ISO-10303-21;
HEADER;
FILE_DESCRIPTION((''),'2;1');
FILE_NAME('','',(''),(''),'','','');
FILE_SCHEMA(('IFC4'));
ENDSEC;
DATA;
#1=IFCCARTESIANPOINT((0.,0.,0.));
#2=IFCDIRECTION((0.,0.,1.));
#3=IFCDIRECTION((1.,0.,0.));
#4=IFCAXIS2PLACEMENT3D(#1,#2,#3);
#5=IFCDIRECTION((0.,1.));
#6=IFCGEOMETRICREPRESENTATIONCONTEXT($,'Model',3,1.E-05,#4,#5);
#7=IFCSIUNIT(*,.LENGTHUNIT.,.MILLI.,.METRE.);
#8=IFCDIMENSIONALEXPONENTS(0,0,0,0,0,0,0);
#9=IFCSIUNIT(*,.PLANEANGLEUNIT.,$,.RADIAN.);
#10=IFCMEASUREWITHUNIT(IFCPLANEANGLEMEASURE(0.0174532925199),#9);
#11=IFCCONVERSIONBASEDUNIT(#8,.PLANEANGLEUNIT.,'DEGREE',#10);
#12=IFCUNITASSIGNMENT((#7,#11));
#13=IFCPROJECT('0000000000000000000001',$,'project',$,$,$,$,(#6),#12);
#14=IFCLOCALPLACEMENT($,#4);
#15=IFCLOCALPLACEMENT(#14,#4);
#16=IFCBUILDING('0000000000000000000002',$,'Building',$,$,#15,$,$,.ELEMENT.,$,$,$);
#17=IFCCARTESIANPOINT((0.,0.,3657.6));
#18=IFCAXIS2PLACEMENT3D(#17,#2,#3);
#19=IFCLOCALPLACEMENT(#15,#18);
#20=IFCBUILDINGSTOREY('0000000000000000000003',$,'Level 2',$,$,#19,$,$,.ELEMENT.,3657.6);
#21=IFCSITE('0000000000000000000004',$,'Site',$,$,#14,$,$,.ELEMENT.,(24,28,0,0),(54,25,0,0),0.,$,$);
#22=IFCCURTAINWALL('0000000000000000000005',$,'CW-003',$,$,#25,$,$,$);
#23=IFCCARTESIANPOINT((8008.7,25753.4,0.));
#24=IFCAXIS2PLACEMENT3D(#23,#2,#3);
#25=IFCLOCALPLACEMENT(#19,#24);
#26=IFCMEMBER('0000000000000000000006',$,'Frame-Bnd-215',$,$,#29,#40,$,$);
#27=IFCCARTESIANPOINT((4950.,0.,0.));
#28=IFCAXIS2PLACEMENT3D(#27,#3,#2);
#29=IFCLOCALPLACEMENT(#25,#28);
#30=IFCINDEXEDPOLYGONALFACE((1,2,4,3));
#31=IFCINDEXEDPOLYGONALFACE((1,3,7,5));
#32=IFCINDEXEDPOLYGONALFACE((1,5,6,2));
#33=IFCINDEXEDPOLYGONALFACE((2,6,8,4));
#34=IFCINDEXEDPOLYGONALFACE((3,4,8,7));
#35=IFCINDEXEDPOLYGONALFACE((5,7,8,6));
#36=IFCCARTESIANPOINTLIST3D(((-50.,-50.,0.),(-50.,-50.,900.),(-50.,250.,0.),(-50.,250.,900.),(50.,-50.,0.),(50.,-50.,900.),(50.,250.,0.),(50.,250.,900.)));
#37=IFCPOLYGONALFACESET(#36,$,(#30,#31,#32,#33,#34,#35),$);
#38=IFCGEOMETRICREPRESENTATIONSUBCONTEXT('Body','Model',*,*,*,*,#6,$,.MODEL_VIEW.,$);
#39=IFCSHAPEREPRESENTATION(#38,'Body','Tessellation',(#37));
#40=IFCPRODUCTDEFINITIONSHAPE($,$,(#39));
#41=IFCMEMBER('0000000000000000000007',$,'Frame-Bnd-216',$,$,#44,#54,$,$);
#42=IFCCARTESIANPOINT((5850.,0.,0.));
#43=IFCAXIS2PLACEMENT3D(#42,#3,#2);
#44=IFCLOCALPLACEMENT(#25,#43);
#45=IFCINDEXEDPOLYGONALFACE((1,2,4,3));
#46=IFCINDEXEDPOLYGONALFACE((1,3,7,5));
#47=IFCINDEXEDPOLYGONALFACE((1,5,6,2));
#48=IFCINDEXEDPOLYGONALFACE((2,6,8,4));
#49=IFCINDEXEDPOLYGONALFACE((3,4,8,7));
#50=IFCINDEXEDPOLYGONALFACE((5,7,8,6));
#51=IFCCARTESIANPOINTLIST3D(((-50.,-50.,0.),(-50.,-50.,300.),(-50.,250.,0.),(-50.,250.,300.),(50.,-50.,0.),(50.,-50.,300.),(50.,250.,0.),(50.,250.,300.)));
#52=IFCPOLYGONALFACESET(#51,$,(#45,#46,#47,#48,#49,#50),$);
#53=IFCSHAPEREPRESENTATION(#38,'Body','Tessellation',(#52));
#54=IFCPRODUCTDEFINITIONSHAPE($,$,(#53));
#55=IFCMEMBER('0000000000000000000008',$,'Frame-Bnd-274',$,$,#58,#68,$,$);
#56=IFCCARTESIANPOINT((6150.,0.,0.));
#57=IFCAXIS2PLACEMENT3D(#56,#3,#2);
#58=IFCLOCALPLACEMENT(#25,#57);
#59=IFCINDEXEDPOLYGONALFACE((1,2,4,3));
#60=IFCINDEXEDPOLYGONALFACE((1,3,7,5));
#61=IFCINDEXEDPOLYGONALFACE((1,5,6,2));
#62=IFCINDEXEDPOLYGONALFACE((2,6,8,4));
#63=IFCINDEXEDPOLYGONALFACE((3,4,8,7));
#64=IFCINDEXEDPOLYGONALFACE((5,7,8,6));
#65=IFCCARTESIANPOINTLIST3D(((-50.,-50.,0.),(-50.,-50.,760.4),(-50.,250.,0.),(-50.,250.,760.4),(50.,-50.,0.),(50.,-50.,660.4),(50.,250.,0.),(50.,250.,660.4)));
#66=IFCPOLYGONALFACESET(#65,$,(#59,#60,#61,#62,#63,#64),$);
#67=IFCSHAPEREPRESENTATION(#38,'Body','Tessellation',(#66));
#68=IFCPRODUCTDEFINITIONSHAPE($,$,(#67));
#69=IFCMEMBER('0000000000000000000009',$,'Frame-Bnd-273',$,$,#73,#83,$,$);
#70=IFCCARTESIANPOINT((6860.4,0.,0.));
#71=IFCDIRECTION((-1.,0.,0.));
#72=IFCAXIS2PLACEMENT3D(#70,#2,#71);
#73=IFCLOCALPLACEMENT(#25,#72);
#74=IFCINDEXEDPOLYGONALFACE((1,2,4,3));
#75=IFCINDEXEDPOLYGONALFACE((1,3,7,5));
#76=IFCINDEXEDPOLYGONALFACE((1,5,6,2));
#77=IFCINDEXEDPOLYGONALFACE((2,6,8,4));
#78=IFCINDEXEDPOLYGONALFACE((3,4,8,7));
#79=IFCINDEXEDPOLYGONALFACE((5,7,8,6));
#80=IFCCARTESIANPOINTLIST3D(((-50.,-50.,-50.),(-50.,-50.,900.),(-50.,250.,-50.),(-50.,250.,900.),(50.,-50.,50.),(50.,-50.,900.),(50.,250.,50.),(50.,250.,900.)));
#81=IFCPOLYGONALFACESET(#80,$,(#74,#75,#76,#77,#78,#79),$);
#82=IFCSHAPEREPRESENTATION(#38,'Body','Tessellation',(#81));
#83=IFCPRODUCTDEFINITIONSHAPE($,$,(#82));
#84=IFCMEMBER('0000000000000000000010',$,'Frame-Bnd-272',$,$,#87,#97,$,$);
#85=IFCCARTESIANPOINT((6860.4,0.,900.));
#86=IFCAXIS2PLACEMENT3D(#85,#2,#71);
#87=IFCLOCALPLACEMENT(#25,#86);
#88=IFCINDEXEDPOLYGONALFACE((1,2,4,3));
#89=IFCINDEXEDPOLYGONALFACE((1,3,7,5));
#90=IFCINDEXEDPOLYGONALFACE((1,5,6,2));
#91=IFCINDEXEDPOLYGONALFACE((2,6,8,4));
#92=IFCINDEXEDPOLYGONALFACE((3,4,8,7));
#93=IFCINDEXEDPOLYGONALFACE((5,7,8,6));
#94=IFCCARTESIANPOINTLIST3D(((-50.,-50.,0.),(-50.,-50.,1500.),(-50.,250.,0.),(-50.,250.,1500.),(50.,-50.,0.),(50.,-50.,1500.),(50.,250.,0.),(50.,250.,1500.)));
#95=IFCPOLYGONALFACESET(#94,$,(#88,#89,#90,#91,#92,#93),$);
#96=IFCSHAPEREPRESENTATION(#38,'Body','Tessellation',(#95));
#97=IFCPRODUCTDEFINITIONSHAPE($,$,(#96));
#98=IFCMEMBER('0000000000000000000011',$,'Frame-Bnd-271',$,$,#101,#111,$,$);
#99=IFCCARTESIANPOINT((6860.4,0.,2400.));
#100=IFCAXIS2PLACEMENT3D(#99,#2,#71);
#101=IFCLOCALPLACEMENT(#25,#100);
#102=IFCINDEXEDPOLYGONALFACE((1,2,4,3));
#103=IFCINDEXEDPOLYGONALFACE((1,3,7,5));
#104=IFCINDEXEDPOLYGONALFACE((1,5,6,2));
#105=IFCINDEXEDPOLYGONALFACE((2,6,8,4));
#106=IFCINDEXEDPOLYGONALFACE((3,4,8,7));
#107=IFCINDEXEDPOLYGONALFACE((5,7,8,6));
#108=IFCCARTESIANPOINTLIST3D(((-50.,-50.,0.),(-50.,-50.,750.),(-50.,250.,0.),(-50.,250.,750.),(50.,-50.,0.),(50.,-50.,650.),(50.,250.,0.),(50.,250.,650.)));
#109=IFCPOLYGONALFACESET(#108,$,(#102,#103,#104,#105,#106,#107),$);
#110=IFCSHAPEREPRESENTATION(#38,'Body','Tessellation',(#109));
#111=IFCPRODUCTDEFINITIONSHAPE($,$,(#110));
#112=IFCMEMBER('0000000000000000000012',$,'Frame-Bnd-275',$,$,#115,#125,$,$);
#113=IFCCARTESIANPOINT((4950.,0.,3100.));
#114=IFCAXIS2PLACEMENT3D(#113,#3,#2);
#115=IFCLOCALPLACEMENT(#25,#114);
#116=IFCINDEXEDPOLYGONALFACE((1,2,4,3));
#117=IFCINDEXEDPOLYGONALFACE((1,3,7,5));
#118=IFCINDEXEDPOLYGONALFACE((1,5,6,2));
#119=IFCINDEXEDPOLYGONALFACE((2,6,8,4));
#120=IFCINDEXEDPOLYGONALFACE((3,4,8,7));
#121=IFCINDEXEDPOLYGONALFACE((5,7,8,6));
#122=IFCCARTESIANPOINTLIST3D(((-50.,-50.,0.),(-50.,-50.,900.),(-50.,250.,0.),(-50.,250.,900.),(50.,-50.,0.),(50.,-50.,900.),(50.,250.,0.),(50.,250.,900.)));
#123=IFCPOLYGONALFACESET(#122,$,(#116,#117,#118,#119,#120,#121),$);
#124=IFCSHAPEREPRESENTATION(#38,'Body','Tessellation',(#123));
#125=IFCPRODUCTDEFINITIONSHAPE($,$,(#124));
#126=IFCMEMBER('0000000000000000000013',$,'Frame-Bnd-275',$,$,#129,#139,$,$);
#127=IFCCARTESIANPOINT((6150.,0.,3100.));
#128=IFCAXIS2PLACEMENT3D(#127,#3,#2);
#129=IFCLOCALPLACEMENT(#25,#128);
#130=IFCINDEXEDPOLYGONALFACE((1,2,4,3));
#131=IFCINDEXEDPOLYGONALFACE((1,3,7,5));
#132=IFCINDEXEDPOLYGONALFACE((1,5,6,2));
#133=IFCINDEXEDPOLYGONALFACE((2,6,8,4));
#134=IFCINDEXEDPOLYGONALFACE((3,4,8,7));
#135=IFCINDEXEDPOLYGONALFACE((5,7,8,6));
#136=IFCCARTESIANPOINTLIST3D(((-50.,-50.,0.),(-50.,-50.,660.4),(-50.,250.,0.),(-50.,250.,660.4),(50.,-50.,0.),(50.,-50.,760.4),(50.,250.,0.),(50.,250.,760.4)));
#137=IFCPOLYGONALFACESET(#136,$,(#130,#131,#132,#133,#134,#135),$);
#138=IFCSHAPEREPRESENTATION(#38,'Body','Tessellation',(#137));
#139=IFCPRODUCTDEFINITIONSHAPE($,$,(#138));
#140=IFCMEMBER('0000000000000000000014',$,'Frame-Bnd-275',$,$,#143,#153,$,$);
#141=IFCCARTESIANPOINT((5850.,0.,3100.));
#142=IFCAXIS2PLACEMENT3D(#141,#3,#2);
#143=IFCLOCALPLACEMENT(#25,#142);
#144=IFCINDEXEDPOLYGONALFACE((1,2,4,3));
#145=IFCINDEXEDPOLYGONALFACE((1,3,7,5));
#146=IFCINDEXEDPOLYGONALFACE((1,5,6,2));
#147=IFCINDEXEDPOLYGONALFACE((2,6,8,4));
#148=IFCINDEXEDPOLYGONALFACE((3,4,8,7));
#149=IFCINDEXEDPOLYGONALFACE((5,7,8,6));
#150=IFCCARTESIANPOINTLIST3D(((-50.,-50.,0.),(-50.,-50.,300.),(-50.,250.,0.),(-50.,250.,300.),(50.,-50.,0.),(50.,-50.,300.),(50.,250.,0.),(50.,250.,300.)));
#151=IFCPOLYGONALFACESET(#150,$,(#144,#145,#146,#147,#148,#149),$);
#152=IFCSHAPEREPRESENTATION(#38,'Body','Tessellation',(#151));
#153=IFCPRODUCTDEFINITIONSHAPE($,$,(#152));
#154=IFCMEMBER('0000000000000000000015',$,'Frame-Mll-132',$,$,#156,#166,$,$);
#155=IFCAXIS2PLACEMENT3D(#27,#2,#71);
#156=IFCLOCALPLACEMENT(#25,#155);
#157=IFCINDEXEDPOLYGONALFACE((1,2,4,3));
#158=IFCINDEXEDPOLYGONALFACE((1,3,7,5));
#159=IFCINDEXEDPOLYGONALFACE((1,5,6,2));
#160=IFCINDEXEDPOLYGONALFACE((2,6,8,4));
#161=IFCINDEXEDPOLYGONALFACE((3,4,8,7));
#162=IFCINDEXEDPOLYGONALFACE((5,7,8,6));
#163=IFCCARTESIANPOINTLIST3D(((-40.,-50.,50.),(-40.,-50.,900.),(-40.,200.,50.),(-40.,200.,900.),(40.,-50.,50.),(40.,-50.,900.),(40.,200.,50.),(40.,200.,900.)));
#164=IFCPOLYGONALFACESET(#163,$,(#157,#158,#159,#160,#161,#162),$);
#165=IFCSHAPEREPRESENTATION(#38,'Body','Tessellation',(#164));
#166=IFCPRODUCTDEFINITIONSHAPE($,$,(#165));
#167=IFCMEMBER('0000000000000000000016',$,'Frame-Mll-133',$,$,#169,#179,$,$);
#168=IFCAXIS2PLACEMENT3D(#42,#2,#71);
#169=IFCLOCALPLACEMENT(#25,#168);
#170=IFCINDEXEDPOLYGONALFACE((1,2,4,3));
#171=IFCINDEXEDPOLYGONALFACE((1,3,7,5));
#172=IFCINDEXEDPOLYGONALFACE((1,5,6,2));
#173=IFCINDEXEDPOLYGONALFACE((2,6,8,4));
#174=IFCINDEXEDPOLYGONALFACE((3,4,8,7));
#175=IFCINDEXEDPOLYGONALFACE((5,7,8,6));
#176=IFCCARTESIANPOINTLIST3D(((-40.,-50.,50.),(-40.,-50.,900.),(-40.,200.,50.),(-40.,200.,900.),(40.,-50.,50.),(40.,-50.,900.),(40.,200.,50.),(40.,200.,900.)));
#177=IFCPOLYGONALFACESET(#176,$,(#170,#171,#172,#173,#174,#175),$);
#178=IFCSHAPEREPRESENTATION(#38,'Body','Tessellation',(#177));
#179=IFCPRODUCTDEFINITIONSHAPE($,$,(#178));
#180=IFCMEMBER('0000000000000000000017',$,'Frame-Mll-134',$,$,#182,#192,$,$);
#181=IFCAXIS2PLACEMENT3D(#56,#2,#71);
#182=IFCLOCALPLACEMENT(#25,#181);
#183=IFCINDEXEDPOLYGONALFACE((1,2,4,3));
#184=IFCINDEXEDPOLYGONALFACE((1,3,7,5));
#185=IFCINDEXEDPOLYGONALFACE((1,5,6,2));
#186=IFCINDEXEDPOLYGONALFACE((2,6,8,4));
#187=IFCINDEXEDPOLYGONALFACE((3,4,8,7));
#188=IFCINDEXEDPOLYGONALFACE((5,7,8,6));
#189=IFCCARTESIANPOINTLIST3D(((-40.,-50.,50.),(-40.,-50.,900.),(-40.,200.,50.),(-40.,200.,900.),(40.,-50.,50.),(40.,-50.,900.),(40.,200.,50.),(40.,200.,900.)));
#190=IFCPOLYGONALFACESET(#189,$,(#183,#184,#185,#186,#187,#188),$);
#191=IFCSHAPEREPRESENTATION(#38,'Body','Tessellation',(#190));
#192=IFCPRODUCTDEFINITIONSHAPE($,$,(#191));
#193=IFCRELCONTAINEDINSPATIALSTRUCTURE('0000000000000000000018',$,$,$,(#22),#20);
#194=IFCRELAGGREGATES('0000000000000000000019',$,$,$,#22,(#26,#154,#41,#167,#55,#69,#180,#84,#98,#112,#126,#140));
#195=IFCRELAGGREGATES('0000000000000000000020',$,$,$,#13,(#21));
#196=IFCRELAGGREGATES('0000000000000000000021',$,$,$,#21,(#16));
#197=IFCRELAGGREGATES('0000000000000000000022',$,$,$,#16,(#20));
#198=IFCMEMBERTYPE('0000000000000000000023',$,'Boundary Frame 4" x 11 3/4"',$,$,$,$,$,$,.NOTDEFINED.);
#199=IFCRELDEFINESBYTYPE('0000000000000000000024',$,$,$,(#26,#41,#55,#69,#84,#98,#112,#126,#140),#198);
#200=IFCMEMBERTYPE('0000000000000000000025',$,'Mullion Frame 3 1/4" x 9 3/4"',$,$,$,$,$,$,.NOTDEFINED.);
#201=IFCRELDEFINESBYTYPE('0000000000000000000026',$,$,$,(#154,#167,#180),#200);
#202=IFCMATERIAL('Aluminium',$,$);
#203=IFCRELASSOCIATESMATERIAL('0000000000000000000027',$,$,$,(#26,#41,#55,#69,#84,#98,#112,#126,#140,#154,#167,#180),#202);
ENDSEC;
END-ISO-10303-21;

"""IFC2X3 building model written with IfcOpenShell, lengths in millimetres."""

from ifc_helpers import new_model, entity, si_unit, converted_unit, direction, frame, origin_with_axes, place, context, subcontext, project, spatial, polyline, outline, extrude, clip, halfspace, material, type_object, element, aggregate, save


model = new_model("IFC2X3")

# Units and contexts
model_context = context("Model", 3, precision=1e-05, world=origin_with_axes(), true_north=direction((0.0, 1.0)))
body_context = subcontext(model_context, "Body", "Model", "MODEL_VIEW")
ifc_project = project(units=[si_unit("LENGTHUNIT", "METRE", prefix="MILLI"), converted_unit("PLANEANGLEUNIT", "DEGREE", entity("IfcPlaneAngleMeasure", 0.0174532925199), si_unit("PLANEANGLEUNIT", "RADIAN"), dimensions=[0, 0, 0, 0, 0, 0, 0])], contexts=[model_context])

# Site, building, storey
site_placement = place(None, origin_with_axes())
site = spatial("IfcSite", under=ifc_project, at=site_placement, Name="Site", CompositionType="ELEMENT", RefLatitude=(24, 28, 0, 0), RefLongitude=(54, 25, 0, 0), RefElevation=0.0)
building_placement = place(site_placement, origin_with_axes())
building = spatial("IfcBuilding", under=site, at=building_placement, Name="Building", CompositionType="ELEMENT")
storey_placement = place(building_placement, frame((0.0, 0.0, 3657.6), z_axis=(0.0, 0.0, 1.0), x_axis=(1.0, 0.0, 0.0)))
storey = spatial("IfcBuildingStorey", under=building, at=storey_placement, Name="Level 2", CompositionType="ELEMENT", Elevation=3657.6)

# Curtain wall, members
curtain_wall_placement = place(storey_placement, frame((8008.7, 25753.4, 0.0), z_axis=(0.0, 0.0, 1.0), x_axis=(1.0, 0.0, 0.0)))
curtain_wall = element("IfcCurtainWall", 1, at=curtain_wall_placement, inside=storey, Name="CW-003")
ifc_material_1 = material(Name="Aluminium")
member_type_1 = type_object("IfcMemberType", Name="Boundary Frame 4\" x 11 3/4\"", PredefinedType="NOTDEFINED")
member_1_placement = place(curtain_wall_placement, frame((4950.0, 0.0, 0.0), z_axis=(1.0, 0.0, 0.0), x_axis=(0.0, 0.0, 1.0)))
member_1 = element("IfcMember", 2, at=member_1_placement, type_object=member_type_1, material=ifc_material_1, Name="Frame-Bnd-215", context=body_context, shape_type="SweptSolid", body=[
    extrude(outline(polyline([(250.0, -50.0), (250.0, 50.0), (-50.0, 50.0), (-50.0, -50.0), (250.0, -50.0)])), frame((0.0, 0.0, 0.0), z_axis=(0.0, 0.0, 1.0), x_axis=(0.0, 1.0, 0.0)), (0.0, 0.0, 1.0), 900.0),
])
member_2_placement = place(curtain_wall_placement, frame((5850.0, 0.0, 0.0), z_axis=(1.0, 0.0, 0.0), x_axis=(0.0, 0.0, 1.0)))
member_2 = element("IfcMember", 3, at=member_2_placement, type_object=member_type_1, material=ifc_material_1, Name="Frame-Bnd-216", context=body_context, shape_type="SweptSolid", body=[
    extrude(outline(polyline([(250.0, -50.0), (250.0, 50.0), (-50.0, 50.0), (-50.0, -50.0), (250.0, -50.0)])), frame((0.0, 0.0, 0.0), z_axis=(0.0, 0.0, 1.0), x_axis=(0.0, 1.0, 0.0)), (0.0, 0.0, 1.0), 300.0),
])
member_3_placement = place(curtain_wall_placement, frame((6150.0, 0.0, 0.0), z_axis=(1.0, 0.0, 0.0), x_axis=(0.0, 0.0, 1.0)))
member_3 = element("IfcMember", 4, at=member_3_placement, type_object=member_type_1, material=ifc_material_1, Name="Frame-Bnd-274", context=body_context, shape_type="Clipping", body=[
    clip(extrude(outline(polyline([(250.0, -50.0), (250.0, 50.0), (-50.0, 50.0), (-50.0, -50.0), (250.0, -50.0)])), frame((0.0, 0.0, 0.0), z_axis=(0.0, 0.0, 1.0), x_axis=(0.0, 1.0, 0.0)), (0.0, 0.0, 1.0), 760.4), halfspace(frame((355.2, 0.0, 355.2), z_axis=(-0.707107, 0.0, -0.707107), x_axis=(0.0, 1.0, 0.0)), True)),
])
member_4_placement = place(curtain_wall_placement, frame((6860.4, 0.0, 0.0), z_axis=(0.0, 0.0, 1.0), x_axis=(-1.0, 0.0, 0.0)))
member_4 = element("IfcMember", 5, at=member_4_placement, type_object=member_type_1, material=ifc_material_1, Name="Frame-Bnd-273", context=body_context, shape_type="Clipping", body=[
    clip(extrude(outline(polyline([(-50.0, -250.0), (50.0, -250.0), (50.0, 50.0), (-50.0, 50.0), (-50.0, -250.0)])), frame((0.0, 0.0, -50.0), z_axis=(0.0, 0.0, 1.0), x_axis=(-1.0, 0.0, 0.0)), (0.0, 0.0, 1.0), 950.0), halfspace(frame((0.0, 0.0, 0.0), z_axis=(-0.707107, 0.0, 0.707107), x_axis=(0.0, -1.0, 0.0)), True)),
])
member_5_placement = place(curtain_wall_placement, frame((6860.4, 0.0, 900.0), z_axis=(0.0, 0.0, 1.0), x_axis=(-1.0, 0.0, 0.0)))
member_5 = element("IfcMember", 6, at=member_5_placement, type_object=member_type_1, material=ifc_material_1, Name="Frame-Bnd-272", context=body_context, shape_type="SweptSolid", body=[
    extrude(outline(polyline([(-50.0, -250.0), (50.0, -250.0), (50.0, 50.0), (-50.0, 50.0), (-50.0, -250.0)])), frame((0.0, 0.0, 0.0), z_axis=(0.0, 0.0, 1.0), x_axis=(-1.0, 0.0, 0.0)), (0.0, 0.0, 1.0), 1500.0),
])
member_6_placement = place(curtain_wall_placement, frame((6860.4, 0.0, 2400.0), z_axis=(0.0, 0.0, 1.0), x_axis=(-1.0, 0.0, 0.0)))
member_6 = element("IfcMember", 7, at=member_6_placement, type_object=member_type_1, material=ifc_material_1, Name="Frame-Bnd-271", context=body_context, shape_type="Clipping", body=[
    clip(extrude(outline(polyline([(-50.0, -250.0), (50.0, -250.0), (50.0, 50.0), (-50.0, 50.0), (-50.0, -250.0)])), frame((0.0, 0.0, 0.0), z_axis=(0.0, 0.0, 1.0), x_axis=(-1.0, 0.0, 0.0)), (0.0, 0.0, 1.0), 750.0), halfspace(frame((350.0, 0.0, 350.0), z_axis=(-0.707107, 0.0, -0.707107), x_axis=(0.0, 1.0, 0.0)), True)),
])
member_7_placement = place(curtain_wall_placement, frame((4950.0, 0.0, 3100.0), z_axis=(1.0, 0.0, 0.0), x_axis=(0.0, 0.0, 1.0)))
member_7 = element("IfcMember", 8, at=member_7_placement, type_object=member_type_1, material=ifc_material_1, Name="Frame-Bnd-275", context=body_context, shape_type="SweptSolid", body=[
    extrude(outline(polyline([(250.0, -50.0), (250.0, 50.0), (-50.0, 50.0), (-50.0, -50.0), (250.0, -50.0)])), frame((0.0, 0.0, 0.0), z_axis=(0.0, 0.0, 1.0), x_axis=(0.0, 1.0, 0.0)), (0.0, 0.0, 1.0), 900.0),
])
member_8_placement = place(curtain_wall_placement, frame((6150.0, 0.0, 3100.0), z_axis=(1.0, 0.0, 0.0), x_axis=(0.0, 0.0, 1.0)))
member_8 = element("IfcMember", 9, at=member_8_placement, type_object=member_type_1, material=ifc_material_1, Name="Frame-Bnd-275", context=body_context, shape_type="Clipping", body=[
    clip(extrude(outline(polyline([(250.0, -50.0), (250.0, 50.0), (-50.0, 50.0), (-50.0, -50.0), (250.0, -50.0)])), frame((0.0, 0.0, 0.0), z_axis=(0.0, 0.0, 1.0), x_axis=(0.0, 1.0, 0.0)), (0.0, 0.0, 1.0), 760.4), halfspace(frame((-355.2, 0.0, 355.2), z_axis=(0.707107, 0.0, -0.707107), x_axis=(0.0, 1.0, 0.0)), True)),
])
member_9_placement = place(curtain_wall_placement, frame((5850.0, 0.0, 3100.0), z_axis=(1.0, 0.0, 0.0), x_axis=(0.0, 0.0, 1.0)))
member_9 = element("IfcMember", 10, at=member_9_placement, type_object=member_type_1, material=ifc_material_1, Name="Frame-Bnd-275", context=body_context, shape_type="SweptSolid", body=[
    extrude(outline(polyline([(250.0, -50.0), (250.0, 50.0), (-50.0, 50.0), (-50.0, -50.0), (250.0, -50.0)])), frame((0.0, 0.0, 0.0), z_axis=(0.0, 0.0, 1.0), x_axis=(0.0, 1.0, 0.0)), (0.0, 0.0, 1.0), 300.0),
])
member_type_2 = type_object("IfcMemberType", Name="Mullion Frame 3 1/4\" x 9 3/4\"", PredefinedType="NOTDEFINED")
member_10_placement = place(curtain_wall_placement, frame((4950.0, 0.0, 0.0), z_axis=(0.0, 0.0, 1.0), x_axis=(-1.0, 0.0, 0.0)))
member_10 = element("IfcMember", 11, at=member_10_placement, type_object=member_type_2, material=ifc_material_1, Name="Frame-Mll-132", context=body_context, shape_type="SweptSolid", body=[
    extrude(outline(polyline([(-40.0, -200.0), (40.0, -200.0), (40.0, 50.0), (-40.0, 50.0), (-40.0, -200.0)])), frame((0.0, 0.0, 50.0), z_axis=(0.0, 0.0, 1.0), x_axis=(-1.0, 0.0, 0.0)), (0.0, 0.0, 1.0), 850.0),
])
member_11_placement = place(curtain_wall_placement, frame((5850.0, 0.0, 0.0), z_axis=(0.0, 0.0, 1.0), x_axis=(-1.0, 0.0, 0.0)))
member_11 = element("IfcMember", 12, at=member_11_placement, type_object=member_type_2, material=ifc_material_1, Name="Frame-Mll-133", context=body_context, shape_type="SweptSolid", body=[
    extrude(outline(polyline([(-40.0, -200.0), (40.0, -200.0), (40.0, 50.0), (-40.0, 50.0), (-40.0, -200.0)])), frame((0.0, 0.0, 50.0), z_axis=(0.0, 0.0, 1.0), x_axis=(-1.0, 0.0, 0.0)), (0.0, 0.0, 1.0), 850.0),
])
member_12_placement = place(curtain_wall_placement, frame((6150.0, 0.0, 0.0), z_axis=(0.0, 0.0, 1.0), x_axis=(-1.0, 0.0, 0.0)))
member_12 = element("IfcMember", 13, at=member_12_placement, type_object=member_type_2, material=ifc_material_1, Name="Frame-Mll-134", context=body_context, shape_type="SweptSolid", body=[
    extrude(outline(polyline([(-40.0, -200.0), (40.0, -200.0), (40.0, 50.0), (-40.0, 50.0), (-40.0, -200.0)])), frame((0.0, 0.0, 50.0), z_axis=(0.0, 0.0, 1.0), x_axis=(-1.0, 0.0, 0.0)), (0.0, 0.0, 1.0), 850.0),
])

aggregate(curtain_wall, [member_1, member_10, member_2, member_11, member_3, member_4, member_12, member_5, member_6, member_7, member_8, member_9])

save(model, "model.ifc")
